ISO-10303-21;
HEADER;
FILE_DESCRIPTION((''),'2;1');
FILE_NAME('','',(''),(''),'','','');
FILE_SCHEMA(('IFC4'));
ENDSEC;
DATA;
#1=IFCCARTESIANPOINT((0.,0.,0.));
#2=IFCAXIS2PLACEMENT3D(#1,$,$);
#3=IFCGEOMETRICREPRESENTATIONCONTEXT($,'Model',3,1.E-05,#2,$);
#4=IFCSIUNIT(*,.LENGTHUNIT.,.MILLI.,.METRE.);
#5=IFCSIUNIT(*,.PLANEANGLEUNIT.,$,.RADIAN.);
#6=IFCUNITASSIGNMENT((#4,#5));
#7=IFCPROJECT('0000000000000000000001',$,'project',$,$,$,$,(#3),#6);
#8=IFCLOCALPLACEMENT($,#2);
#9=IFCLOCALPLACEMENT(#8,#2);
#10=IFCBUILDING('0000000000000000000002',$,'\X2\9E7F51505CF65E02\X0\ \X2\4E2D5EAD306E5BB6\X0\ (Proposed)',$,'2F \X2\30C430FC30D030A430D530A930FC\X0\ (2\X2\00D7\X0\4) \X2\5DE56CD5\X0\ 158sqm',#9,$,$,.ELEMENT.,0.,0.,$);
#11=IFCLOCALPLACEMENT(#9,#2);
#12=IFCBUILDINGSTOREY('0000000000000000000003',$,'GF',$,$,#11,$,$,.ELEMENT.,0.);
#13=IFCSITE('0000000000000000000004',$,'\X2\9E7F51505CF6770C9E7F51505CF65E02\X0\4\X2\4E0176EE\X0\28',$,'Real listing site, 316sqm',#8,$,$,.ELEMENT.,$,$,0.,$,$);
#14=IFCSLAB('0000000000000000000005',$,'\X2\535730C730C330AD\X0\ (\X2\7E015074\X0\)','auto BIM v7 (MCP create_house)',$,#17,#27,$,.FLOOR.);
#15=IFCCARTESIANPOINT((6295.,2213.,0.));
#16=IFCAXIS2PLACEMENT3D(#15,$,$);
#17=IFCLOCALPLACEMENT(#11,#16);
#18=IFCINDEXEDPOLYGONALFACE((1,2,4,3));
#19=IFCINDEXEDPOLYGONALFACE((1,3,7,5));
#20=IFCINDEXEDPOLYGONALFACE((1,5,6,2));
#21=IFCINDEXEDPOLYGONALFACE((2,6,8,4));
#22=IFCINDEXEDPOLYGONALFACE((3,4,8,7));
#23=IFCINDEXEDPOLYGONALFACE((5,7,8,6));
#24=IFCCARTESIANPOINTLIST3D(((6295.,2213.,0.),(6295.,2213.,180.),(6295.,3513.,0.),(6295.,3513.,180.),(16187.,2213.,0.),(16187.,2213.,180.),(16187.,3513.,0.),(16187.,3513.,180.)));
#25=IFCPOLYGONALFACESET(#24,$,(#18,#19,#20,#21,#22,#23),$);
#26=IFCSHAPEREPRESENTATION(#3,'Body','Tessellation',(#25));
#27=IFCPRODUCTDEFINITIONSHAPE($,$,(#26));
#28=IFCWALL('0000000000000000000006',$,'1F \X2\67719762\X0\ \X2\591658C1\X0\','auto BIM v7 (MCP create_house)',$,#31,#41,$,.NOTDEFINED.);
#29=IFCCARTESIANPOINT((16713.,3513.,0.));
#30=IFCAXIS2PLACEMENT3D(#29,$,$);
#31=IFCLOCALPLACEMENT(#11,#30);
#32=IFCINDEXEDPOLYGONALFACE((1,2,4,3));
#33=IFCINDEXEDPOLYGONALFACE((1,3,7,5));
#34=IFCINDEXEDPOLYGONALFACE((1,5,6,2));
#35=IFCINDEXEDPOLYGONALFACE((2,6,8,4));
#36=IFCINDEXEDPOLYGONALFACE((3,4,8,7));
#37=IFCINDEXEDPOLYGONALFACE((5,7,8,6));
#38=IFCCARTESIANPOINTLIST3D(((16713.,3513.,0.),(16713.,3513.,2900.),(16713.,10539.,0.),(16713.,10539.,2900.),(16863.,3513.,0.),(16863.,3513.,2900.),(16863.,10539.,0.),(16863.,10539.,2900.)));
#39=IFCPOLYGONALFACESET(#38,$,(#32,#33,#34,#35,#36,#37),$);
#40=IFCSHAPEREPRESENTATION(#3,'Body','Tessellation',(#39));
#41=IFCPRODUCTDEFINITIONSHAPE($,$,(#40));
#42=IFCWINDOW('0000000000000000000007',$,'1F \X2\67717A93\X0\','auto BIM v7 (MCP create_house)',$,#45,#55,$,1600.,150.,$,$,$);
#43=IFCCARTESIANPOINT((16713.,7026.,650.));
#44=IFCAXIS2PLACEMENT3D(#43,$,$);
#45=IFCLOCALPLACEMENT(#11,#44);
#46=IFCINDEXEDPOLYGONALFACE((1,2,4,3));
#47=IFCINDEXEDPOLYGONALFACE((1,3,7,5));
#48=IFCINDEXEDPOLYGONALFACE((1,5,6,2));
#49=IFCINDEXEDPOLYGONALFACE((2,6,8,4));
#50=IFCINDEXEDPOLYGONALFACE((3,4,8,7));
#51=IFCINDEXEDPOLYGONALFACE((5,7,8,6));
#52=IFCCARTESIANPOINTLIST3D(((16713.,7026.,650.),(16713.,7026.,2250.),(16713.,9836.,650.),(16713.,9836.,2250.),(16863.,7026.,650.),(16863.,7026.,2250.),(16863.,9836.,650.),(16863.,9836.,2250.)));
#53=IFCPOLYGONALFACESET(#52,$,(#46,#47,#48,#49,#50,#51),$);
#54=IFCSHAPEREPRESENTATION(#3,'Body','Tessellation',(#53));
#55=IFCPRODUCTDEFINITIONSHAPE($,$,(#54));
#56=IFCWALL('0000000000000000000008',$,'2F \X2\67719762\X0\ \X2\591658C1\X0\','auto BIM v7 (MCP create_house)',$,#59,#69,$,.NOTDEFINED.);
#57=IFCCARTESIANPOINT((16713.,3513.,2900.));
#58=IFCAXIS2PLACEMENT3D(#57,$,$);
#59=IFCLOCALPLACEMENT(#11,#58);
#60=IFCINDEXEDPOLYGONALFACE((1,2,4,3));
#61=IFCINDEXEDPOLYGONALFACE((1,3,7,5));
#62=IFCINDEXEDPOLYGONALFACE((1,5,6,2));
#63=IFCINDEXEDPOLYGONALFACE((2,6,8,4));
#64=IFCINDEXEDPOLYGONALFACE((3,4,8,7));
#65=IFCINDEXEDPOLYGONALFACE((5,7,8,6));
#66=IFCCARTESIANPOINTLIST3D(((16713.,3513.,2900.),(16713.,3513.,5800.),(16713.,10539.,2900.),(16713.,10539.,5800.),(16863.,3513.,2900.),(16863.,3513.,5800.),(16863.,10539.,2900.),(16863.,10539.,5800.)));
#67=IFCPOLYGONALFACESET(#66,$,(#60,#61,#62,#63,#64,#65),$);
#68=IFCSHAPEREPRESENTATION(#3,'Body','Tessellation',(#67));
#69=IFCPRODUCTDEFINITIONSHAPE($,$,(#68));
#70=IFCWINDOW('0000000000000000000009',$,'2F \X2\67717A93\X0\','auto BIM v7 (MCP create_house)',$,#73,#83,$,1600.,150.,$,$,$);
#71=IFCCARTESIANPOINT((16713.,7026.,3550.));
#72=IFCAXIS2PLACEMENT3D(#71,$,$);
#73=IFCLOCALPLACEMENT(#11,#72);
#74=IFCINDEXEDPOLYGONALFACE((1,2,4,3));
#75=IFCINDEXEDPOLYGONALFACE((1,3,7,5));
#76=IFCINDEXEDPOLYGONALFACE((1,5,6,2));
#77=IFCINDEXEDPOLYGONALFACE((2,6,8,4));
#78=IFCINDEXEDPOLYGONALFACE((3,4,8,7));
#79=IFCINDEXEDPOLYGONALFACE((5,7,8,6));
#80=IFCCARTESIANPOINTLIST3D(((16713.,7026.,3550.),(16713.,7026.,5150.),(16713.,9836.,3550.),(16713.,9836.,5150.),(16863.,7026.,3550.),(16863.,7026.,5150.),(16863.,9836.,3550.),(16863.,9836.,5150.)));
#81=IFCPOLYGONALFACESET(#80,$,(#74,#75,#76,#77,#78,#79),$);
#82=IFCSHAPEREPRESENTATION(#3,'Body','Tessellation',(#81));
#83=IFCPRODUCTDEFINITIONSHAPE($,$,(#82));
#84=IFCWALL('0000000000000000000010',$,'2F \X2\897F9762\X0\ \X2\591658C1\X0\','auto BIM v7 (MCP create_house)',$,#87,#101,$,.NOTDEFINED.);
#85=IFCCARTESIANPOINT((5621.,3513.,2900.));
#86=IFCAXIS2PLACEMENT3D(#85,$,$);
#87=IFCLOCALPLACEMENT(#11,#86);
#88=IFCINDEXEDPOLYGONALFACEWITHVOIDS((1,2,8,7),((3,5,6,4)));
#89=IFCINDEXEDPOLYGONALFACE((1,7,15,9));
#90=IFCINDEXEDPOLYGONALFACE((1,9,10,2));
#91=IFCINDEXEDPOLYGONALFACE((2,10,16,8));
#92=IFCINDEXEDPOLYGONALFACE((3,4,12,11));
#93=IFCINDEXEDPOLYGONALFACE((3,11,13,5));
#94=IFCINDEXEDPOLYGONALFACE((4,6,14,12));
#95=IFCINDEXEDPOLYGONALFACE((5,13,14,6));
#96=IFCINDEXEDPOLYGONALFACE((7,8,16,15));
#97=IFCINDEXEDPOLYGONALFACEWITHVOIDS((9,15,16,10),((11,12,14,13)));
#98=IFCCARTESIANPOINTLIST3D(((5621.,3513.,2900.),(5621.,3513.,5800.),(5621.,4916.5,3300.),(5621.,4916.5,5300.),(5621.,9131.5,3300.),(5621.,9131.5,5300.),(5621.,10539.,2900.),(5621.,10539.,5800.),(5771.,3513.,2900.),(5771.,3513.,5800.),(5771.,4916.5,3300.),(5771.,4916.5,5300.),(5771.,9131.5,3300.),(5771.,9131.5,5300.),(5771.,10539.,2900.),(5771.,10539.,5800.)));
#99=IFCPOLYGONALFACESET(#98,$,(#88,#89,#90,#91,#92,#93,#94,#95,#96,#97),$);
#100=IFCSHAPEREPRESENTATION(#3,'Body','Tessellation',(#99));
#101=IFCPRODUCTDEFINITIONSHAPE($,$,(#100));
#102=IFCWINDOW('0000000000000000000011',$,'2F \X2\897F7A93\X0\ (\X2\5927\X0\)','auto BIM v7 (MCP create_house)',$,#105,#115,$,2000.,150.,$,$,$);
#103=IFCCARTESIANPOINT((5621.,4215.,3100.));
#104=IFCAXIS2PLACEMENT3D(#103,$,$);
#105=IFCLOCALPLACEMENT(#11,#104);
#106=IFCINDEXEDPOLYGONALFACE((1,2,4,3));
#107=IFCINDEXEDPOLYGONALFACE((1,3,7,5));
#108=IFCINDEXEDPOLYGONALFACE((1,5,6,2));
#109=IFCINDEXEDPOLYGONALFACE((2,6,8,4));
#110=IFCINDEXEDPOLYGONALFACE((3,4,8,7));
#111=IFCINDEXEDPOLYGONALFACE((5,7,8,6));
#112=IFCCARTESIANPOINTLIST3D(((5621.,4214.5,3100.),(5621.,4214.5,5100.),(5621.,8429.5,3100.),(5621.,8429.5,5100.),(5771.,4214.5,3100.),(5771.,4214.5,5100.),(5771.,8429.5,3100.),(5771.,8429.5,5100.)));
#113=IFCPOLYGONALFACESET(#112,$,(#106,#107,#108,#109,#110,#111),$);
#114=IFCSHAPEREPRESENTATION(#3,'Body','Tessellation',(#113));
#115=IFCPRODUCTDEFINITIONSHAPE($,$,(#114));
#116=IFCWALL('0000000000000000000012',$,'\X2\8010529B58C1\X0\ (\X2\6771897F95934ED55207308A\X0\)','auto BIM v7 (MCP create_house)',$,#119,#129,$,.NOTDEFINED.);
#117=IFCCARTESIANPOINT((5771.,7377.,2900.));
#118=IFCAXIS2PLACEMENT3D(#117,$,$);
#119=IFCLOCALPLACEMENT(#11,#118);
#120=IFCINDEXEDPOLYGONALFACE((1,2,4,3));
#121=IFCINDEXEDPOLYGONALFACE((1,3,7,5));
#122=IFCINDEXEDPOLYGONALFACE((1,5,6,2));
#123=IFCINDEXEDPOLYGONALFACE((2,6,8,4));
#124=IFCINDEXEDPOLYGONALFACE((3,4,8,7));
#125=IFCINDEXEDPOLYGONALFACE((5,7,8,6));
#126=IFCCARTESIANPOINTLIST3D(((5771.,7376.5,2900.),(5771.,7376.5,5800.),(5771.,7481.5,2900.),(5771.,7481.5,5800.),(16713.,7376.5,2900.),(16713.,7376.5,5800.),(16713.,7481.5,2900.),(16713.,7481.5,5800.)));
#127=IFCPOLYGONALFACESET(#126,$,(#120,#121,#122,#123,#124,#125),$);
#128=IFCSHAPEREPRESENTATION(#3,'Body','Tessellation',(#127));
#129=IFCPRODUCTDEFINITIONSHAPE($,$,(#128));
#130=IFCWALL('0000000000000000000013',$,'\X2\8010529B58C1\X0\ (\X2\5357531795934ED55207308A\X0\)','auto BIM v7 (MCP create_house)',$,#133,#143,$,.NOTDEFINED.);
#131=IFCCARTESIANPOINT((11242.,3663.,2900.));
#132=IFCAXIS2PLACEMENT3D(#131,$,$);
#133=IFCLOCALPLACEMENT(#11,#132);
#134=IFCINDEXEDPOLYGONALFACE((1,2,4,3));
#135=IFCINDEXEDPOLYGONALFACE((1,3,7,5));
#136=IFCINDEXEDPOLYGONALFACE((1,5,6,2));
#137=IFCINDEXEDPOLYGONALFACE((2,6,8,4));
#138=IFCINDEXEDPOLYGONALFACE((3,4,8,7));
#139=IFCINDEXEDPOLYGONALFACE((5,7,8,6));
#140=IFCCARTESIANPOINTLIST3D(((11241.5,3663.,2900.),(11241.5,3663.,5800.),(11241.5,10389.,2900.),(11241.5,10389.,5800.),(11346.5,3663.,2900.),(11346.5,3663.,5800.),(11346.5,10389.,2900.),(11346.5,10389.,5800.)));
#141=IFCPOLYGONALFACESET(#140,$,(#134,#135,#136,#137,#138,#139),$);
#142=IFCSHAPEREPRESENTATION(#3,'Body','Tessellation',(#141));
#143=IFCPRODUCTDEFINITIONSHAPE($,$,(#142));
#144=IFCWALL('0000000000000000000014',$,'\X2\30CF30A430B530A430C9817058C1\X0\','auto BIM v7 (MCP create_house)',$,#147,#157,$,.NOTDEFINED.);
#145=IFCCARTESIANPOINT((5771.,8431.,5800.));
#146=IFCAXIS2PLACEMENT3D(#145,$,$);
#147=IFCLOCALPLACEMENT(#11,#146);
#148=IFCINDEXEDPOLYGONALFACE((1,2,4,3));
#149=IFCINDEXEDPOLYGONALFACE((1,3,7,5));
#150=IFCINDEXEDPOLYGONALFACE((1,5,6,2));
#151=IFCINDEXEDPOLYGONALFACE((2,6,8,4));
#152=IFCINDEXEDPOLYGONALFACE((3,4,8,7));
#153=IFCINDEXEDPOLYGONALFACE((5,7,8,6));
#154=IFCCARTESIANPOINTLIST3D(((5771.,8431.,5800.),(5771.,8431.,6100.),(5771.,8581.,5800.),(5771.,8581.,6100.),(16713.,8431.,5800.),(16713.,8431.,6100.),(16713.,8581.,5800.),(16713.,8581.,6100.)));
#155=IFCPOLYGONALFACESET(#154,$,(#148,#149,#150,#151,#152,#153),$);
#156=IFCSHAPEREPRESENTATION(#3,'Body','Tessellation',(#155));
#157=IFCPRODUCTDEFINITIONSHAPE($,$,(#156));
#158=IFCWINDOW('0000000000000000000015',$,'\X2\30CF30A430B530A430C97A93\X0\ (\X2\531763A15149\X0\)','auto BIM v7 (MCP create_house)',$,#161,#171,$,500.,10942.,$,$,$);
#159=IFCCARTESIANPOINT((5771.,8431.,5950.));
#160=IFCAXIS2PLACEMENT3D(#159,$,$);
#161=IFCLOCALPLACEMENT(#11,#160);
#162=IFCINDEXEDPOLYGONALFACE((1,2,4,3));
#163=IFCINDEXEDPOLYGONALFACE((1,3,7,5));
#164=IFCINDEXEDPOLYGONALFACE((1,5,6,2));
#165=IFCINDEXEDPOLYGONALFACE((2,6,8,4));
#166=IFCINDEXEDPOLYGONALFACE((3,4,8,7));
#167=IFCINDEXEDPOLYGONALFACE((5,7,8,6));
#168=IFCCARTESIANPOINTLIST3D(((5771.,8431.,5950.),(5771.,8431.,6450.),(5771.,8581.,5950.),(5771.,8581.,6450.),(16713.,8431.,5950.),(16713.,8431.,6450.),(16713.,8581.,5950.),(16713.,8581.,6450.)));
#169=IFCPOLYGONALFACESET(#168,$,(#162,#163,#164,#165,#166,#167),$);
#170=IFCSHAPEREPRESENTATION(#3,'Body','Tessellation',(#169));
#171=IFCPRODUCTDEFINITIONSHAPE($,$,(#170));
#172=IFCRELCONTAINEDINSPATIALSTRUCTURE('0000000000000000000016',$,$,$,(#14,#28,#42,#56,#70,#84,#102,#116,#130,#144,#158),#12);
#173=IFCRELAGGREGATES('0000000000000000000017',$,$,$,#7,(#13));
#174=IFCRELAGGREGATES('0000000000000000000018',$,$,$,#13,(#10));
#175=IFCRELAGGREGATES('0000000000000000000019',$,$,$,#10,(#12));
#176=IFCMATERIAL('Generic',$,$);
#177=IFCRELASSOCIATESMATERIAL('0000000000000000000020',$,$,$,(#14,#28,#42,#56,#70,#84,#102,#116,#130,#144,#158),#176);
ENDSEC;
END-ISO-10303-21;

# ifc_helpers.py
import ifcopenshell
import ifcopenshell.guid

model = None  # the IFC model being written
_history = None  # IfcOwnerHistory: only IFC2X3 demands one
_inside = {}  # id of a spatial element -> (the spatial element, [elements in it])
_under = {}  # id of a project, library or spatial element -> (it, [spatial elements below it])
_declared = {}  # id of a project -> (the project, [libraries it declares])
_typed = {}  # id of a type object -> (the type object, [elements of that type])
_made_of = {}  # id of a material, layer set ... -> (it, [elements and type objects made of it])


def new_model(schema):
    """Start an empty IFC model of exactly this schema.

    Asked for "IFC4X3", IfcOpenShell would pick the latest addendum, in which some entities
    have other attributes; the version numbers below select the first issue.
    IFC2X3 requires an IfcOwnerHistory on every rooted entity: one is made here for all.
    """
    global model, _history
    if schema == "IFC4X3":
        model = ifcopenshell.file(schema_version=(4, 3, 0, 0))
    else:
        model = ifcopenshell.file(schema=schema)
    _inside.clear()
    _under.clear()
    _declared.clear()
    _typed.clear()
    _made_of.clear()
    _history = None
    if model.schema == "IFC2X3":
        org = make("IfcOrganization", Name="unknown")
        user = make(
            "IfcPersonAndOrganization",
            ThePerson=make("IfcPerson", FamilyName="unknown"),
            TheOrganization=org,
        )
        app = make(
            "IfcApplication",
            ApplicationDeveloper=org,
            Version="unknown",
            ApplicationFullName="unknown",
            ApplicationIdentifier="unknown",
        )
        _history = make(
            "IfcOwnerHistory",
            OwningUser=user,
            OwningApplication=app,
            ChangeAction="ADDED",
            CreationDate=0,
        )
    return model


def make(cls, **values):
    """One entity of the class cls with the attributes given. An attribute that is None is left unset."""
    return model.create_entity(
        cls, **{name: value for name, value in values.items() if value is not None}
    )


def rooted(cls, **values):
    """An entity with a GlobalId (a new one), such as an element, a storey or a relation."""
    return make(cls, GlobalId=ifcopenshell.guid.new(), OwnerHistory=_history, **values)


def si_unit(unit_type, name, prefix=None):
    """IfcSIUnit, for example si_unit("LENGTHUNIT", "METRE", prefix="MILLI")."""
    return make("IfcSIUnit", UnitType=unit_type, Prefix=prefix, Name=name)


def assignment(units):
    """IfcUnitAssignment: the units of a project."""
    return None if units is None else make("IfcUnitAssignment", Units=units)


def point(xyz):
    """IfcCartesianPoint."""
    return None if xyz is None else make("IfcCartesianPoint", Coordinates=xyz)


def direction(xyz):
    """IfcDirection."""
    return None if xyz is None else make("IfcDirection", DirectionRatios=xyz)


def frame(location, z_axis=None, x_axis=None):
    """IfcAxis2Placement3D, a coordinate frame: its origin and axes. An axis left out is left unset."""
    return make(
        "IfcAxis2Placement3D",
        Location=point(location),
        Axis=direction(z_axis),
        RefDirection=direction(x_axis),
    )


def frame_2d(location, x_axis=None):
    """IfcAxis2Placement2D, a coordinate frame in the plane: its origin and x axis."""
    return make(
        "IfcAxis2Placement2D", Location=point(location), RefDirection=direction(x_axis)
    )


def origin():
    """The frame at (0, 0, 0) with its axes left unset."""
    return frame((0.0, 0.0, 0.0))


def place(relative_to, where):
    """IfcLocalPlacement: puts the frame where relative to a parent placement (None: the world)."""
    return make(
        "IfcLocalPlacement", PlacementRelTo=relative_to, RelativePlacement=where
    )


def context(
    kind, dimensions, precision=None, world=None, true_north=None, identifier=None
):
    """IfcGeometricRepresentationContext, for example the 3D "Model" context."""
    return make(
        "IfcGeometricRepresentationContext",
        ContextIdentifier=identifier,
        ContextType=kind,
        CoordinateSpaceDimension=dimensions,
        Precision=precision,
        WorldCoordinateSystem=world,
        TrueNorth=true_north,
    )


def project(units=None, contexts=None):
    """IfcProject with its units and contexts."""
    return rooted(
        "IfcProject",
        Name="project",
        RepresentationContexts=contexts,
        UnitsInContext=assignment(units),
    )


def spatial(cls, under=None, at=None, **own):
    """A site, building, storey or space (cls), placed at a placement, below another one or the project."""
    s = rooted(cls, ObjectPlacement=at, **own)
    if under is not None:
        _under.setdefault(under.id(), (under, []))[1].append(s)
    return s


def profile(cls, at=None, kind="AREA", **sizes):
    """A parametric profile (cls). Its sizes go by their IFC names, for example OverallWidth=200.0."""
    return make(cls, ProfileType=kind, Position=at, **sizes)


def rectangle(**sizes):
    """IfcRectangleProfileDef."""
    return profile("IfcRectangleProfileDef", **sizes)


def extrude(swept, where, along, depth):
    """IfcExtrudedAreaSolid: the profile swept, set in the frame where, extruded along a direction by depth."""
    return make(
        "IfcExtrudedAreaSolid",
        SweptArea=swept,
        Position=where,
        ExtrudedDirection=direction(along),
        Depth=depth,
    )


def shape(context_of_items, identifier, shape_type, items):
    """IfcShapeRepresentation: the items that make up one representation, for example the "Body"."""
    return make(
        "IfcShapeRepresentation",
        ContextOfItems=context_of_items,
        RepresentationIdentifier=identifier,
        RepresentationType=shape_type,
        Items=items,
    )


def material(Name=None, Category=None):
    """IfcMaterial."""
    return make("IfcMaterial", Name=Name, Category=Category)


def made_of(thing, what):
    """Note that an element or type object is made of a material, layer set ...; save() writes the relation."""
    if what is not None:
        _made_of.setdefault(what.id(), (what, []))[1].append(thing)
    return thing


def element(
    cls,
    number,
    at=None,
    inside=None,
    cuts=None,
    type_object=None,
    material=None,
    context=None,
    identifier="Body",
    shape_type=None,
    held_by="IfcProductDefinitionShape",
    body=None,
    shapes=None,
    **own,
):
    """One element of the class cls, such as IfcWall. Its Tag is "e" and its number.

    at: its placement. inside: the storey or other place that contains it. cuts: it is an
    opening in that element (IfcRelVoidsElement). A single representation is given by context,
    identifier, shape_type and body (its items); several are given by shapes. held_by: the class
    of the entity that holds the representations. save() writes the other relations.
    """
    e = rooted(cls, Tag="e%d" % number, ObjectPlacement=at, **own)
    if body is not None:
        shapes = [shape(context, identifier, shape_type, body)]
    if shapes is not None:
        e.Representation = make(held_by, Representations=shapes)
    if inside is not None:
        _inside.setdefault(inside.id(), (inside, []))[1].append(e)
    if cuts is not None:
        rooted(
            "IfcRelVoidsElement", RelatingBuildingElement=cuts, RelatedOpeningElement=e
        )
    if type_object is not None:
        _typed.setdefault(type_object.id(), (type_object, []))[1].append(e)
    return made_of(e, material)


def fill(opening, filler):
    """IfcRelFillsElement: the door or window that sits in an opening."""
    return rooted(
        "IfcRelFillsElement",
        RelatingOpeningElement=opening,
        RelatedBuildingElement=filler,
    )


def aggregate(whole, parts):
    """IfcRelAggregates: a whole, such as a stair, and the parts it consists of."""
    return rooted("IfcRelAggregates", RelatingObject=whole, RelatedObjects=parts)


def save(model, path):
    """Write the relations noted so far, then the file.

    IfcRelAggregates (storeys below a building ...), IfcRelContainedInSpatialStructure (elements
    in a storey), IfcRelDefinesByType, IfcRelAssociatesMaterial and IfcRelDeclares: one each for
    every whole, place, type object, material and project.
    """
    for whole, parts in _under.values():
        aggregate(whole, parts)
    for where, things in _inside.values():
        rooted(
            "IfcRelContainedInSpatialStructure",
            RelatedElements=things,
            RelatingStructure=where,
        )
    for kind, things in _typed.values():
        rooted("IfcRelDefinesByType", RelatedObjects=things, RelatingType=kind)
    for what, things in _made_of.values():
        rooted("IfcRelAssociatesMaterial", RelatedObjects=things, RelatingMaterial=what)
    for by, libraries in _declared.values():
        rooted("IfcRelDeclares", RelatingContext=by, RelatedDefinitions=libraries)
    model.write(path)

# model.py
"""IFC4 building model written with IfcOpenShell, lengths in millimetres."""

from ifc_helpers import new_model, si_unit, frame, frame_2d, origin, place, context, project, spatial, rectangle, extrude, material, element, fill, save


model = new_model("IFC4")

# Units and contexts
model_context = context("Model", 3, precision=1e-05, world=origin())
ifc_project = project(units=[si_unit("LENGTHUNIT", "METRE", prefix="MILLI"), si_unit("PLANEANGLEUNIT", "RADIAN")], contexts=[model_context])

# Site, building, storey
site_placement = place(None, origin())
site = spatial("IfcSite", under=ifc_project, at=site_placement, Name="鹿児島県鹿児島市4丁目28", ObjectType="Real listing site, 316sqm", CompositionType="ELEMENT", RefElevation=0.0)
building_placement = place(site_placement, origin())
building = spatial("IfcBuilding", under=site, at=building_placement, Name="鹿児島市 中庭の家 (Proposed)", ObjectType="2F ツーバイフォー (2×4) 工法 158sqm", CompositionType="ELEMENT", ElevationOfRefHeight=0.0, ElevationOfTerrain=0.0)
storey_placement = place(building_placement, origin())
storey = spatial("IfcBuildingStorey", under=building, at=storey_placement, Name="GF", CompositionType="ELEMENT", Elevation=0.0)

# Slab
ifc_material = material(Name="Generic")
slab_placement = place(storey_placement, frame((6295.0, 2213.0, 0.0)))
element("IfcSlab", 1, at=slab_placement, inside=storey, material=ifc_material, Name="南デッキ (縁側)", Description="auto BIM v7 (MCP create_house)", PredefinedType="FLOOR", context=model_context, shape_type="SweptSolid", body=[
    extrude(rectangle(XDim=9892.0, YDim=1300.0, at=frame_2d((4946.0, 650.0))), frame((6295.0, 2213.0, 0.0)), (0.0, 0.0, 1.0), 180.0),
])

# Wall, opening, window
wall_1_placement = place(storey_placement, frame((16713.0, 3513.0, 0.0)))
wall_1 = element("IfcWall", 2, at=wall_1_placement, inside=storey, material=ifc_material, Name="1F 東面 外壁", Description="auto BIM v7 (MCP create_house)", PredefinedType="NOTDEFINED", context=model_context, shape_type="SweptSolid", body=[
    extrude(rectangle(XDim=150.0, YDim=7026.0, at=frame_2d((75.0, 3513.0))), frame((16713.0, 3513.0, 0.0)), (0.0, 0.0, 1.0), 2900.0),
])
opening_1_placement = place(storey_placement, frame((16713.0, 7026.0, 650.0)))
opening_1 = element("IfcOpeningElement", 3, at=opening_1_placement, cuts=wall_1, PredefinedType="NOTDEFINED", context=model_context, shape_type="SweptSolid", body=[
    extrude(rectangle(XDim=150.0, YDim=2810.0, at=frame_2d((75.0, 1405.0))), frame((16713.0, 7026.0, 650.0)), (0.0, 0.0, 1.0), 1600.0),
])
window_1_placement = place(storey_placement, frame((16713.0, 7026.0, 650.0)))
window_1 = element("IfcWindow", 4, at=window_1_placement, inside=storey, material=ifc_material, Name="1F 東窓", Description="auto BIM v7 (MCP create_house)", OverallHeight=1600.0, OverallWidth=150.0, context=model_context, shape_type="SweptSolid", body=[
    extrude(rectangle(XDim=150.0, YDim=2810.0, at=frame_2d((75.0, 1405.0))), frame((16713.0, 7026.0, 650.0)), (0.0, 0.0, 1.0), 1600.0),
])
fill(opening_1, window_1)

# Walls, openings, windows
wall_2_placement = place(storey_placement, frame((16713.0, 3513.0, 2900.0)))
wall_2 = element("IfcWall", 5, at=wall_2_placement, inside=storey, material=ifc_material, Name="2F 東面 外壁", Description="auto BIM v7 (MCP create_house)", PredefinedType="NOTDEFINED", context=model_context, shape_type="SweptSolid", body=[
    extrude(rectangle(XDim=150.0, YDim=7026.0, at=frame_2d((75.0, 3513.0))), frame((16713.0, 3513.0, 2900.0)), (0.0, 0.0, 1.0), 2900.0),
])
opening_2_placement = place(storey_placement, frame((16713.0, 7026.0, 3550.0)))
opening_2 = element("IfcOpeningElement", 6, at=opening_2_placement, cuts=wall_2, PredefinedType="NOTDEFINED", context=model_context, shape_type="SweptSolid", body=[
    extrude(rectangle(XDim=150.0, YDim=2810.0, at=frame_2d((75.0, 1405.0))), frame((16713.0, 7026.0, 3550.0)), (0.0, 0.0, 1.0), 1600.0),
])
window_2_placement = place(storey_placement, frame((16713.0, 7026.0, 3550.0)))
window_2 = element("IfcWindow", 7, at=window_2_placement, inside=storey, material=ifc_material, Name="2F 東窓", Description="auto BIM v7 (MCP create_house)", OverallHeight=1600.0, OverallWidth=150.0, context=model_context, shape_type="SweptSolid", body=[
    extrude(rectangle(XDim=150.0, YDim=2810.0, at=frame_2d((75.0, 1405.0))), frame((16713.0, 7026.0, 3550.0)), (0.0, 0.0, 1.0), 1600.0),
])
fill(opening_2, window_2)
wall_3_placement = place(storey_placement, frame((5621.0, 3513.0, 2900.0)))
wall_3 = element("IfcWall", 8, at=wall_3_placement, inside=storey, material=ifc_material, Name="2F 西面 外壁", Description="auto BIM v7 (MCP create_house)", PredefinedType="NOTDEFINED", context=model_context, shape_type="SweptSolid", body=[
    extrude(rectangle(XDim=150.0, YDim=7026.0, at=frame_2d((75.0, 3513.0))), frame((5621.0, 3513.0, 2900.0)), (0.0, 0.0, 1.0), 2900.0),
])
opening_3_placement = place(storey_placement, frame((5621.0, 4215.0, 3100.0)))
opening_3 = element("IfcOpeningElement", 9, at=opening_3_placement, cuts=wall_3, PredefinedType="NOTDEFINED", context=model_context, shape_type="SweptSolid", body=[
    extrude(rectangle(XDim=150.0, YDim=4215.0, at=frame_2d((75.0, 2107.0))), frame((5621.0, 4215.0, 3100.0)), (0.0, 0.0, 1.0), 2000.0),
])
window_3_placement = place(storey_placement, frame((5621.0, 4215.0, 3100.0)))
window_3 = element("IfcWindow", 10, at=window_3_placement, inside=storey, material=ifc_material, Name="2F 西窓 (大)", Description="auto BIM v7 (MCP create_house)", OverallHeight=2000.0, OverallWidth=150.0, context=model_context, shape_type="SweptSolid", body=[
    extrude(rectangle(XDim=150.0, YDim=4215.0, at=frame_2d((75.0, 2107.0))), frame((5621.0, 4215.0, 3100.0)), (0.0, 0.0, 1.0), 2000.0),
])
fill(opening_3, window_3)

# Walls
wall_4_placement = place(storey_placement, frame((5771.0, 7377.0, 2900.0)))
element("IfcWall", 11, at=wall_4_placement, inside=storey, material=ifc_material, Name="耐力壁 (東西間仕切り)", Description="auto BIM v7 (MCP create_house)", PredefinedType="NOTDEFINED", context=model_context, shape_type="SweptSolid", body=[
    extrude(rectangle(XDim=10942.0, YDim=105.0, at=frame_2d((5471.0, 52.0))), frame((5771.0, 7377.0, 2900.0)), (0.0, 0.0, 1.0), 2900.0),
])
wall_5_placement = place(storey_placement, frame((11242.0, 3663.0, 2900.0)))
element("IfcWall", 12, at=wall_5_placement, inside=storey, material=ifc_material, Name="耐力壁 (南北間仕切り)", Description="auto BIM v7 (MCP create_house)", PredefinedType="NOTDEFINED", context=model_context, shape_type="SweptSolid", body=[
    extrude(rectangle(XDim=105.0, YDim=6726.0, at=frame_2d((52.0, 3363.0))), frame((11242.0, 3663.0, 2900.0)), (0.0, 0.0, 1.0), 2900.0),
])

# Wall, opening, window
wall_6_placement = place(storey_placement, frame((5771.0, 8431.0, 5800.0)))
wall_6 = element("IfcWall", 13, at=wall_6_placement, inside=storey, material=ifc_material, Name="ハイサイド腰壁", Description="auto BIM v7 (MCP create_house)", PredefinedType="NOTDEFINED", context=model_context, shape_type="SweptSolid", body=[
    extrude(rectangle(XDim=10942.0, YDim=150.0, at=frame_2d((5471.0, 75.0))), frame((5771.0, 8431.0, 5800.0)), (0.0, 0.0, 1.0), 700.0),
])
opening_4_placement = place(storey_placement, frame((5771.0, 8431.0, 5950.0)))
opening_4 = element("IfcOpeningElement", 14, at=opening_4_placement, cuts=wall_6, PredefinedType="NOTDEFINED", context=model_context, shape_type="SweptSolid", body=[
    extrude(rectangle(XDim=10942.0, YDim=150.0, at=frame_2d((5471.0, 75.0))), frame((5771.0, 8431.0, 5950.0)), (0.0, 0.0, 1.0), 500.0),
])
window_4_placement = place(storey_placement, frame((5771.0, 8431.0, 5950.0)))
window_4 = element("IfcWindow", 15, at=window_4_placement, inside=storey, material=ifc_material, Name="ハイサイド窓 (北採光)", Description="auto BIM v7 (MCP create_house)", OverallHeight=500.0, OverallWidth=10942.0, context=model_context, shape_type="SweptSolid", body=[
    extrude(rectangle(XDim=10942.0, YDim=150.0, at=frame_2d((5471.0, 75.0))), frame((5771.0, 8431.0, 5950.0)), (0.0, 0.0, 1.0), 500.0),
])
fill(opening_4, window_4)

save(model, "model.ifc")
